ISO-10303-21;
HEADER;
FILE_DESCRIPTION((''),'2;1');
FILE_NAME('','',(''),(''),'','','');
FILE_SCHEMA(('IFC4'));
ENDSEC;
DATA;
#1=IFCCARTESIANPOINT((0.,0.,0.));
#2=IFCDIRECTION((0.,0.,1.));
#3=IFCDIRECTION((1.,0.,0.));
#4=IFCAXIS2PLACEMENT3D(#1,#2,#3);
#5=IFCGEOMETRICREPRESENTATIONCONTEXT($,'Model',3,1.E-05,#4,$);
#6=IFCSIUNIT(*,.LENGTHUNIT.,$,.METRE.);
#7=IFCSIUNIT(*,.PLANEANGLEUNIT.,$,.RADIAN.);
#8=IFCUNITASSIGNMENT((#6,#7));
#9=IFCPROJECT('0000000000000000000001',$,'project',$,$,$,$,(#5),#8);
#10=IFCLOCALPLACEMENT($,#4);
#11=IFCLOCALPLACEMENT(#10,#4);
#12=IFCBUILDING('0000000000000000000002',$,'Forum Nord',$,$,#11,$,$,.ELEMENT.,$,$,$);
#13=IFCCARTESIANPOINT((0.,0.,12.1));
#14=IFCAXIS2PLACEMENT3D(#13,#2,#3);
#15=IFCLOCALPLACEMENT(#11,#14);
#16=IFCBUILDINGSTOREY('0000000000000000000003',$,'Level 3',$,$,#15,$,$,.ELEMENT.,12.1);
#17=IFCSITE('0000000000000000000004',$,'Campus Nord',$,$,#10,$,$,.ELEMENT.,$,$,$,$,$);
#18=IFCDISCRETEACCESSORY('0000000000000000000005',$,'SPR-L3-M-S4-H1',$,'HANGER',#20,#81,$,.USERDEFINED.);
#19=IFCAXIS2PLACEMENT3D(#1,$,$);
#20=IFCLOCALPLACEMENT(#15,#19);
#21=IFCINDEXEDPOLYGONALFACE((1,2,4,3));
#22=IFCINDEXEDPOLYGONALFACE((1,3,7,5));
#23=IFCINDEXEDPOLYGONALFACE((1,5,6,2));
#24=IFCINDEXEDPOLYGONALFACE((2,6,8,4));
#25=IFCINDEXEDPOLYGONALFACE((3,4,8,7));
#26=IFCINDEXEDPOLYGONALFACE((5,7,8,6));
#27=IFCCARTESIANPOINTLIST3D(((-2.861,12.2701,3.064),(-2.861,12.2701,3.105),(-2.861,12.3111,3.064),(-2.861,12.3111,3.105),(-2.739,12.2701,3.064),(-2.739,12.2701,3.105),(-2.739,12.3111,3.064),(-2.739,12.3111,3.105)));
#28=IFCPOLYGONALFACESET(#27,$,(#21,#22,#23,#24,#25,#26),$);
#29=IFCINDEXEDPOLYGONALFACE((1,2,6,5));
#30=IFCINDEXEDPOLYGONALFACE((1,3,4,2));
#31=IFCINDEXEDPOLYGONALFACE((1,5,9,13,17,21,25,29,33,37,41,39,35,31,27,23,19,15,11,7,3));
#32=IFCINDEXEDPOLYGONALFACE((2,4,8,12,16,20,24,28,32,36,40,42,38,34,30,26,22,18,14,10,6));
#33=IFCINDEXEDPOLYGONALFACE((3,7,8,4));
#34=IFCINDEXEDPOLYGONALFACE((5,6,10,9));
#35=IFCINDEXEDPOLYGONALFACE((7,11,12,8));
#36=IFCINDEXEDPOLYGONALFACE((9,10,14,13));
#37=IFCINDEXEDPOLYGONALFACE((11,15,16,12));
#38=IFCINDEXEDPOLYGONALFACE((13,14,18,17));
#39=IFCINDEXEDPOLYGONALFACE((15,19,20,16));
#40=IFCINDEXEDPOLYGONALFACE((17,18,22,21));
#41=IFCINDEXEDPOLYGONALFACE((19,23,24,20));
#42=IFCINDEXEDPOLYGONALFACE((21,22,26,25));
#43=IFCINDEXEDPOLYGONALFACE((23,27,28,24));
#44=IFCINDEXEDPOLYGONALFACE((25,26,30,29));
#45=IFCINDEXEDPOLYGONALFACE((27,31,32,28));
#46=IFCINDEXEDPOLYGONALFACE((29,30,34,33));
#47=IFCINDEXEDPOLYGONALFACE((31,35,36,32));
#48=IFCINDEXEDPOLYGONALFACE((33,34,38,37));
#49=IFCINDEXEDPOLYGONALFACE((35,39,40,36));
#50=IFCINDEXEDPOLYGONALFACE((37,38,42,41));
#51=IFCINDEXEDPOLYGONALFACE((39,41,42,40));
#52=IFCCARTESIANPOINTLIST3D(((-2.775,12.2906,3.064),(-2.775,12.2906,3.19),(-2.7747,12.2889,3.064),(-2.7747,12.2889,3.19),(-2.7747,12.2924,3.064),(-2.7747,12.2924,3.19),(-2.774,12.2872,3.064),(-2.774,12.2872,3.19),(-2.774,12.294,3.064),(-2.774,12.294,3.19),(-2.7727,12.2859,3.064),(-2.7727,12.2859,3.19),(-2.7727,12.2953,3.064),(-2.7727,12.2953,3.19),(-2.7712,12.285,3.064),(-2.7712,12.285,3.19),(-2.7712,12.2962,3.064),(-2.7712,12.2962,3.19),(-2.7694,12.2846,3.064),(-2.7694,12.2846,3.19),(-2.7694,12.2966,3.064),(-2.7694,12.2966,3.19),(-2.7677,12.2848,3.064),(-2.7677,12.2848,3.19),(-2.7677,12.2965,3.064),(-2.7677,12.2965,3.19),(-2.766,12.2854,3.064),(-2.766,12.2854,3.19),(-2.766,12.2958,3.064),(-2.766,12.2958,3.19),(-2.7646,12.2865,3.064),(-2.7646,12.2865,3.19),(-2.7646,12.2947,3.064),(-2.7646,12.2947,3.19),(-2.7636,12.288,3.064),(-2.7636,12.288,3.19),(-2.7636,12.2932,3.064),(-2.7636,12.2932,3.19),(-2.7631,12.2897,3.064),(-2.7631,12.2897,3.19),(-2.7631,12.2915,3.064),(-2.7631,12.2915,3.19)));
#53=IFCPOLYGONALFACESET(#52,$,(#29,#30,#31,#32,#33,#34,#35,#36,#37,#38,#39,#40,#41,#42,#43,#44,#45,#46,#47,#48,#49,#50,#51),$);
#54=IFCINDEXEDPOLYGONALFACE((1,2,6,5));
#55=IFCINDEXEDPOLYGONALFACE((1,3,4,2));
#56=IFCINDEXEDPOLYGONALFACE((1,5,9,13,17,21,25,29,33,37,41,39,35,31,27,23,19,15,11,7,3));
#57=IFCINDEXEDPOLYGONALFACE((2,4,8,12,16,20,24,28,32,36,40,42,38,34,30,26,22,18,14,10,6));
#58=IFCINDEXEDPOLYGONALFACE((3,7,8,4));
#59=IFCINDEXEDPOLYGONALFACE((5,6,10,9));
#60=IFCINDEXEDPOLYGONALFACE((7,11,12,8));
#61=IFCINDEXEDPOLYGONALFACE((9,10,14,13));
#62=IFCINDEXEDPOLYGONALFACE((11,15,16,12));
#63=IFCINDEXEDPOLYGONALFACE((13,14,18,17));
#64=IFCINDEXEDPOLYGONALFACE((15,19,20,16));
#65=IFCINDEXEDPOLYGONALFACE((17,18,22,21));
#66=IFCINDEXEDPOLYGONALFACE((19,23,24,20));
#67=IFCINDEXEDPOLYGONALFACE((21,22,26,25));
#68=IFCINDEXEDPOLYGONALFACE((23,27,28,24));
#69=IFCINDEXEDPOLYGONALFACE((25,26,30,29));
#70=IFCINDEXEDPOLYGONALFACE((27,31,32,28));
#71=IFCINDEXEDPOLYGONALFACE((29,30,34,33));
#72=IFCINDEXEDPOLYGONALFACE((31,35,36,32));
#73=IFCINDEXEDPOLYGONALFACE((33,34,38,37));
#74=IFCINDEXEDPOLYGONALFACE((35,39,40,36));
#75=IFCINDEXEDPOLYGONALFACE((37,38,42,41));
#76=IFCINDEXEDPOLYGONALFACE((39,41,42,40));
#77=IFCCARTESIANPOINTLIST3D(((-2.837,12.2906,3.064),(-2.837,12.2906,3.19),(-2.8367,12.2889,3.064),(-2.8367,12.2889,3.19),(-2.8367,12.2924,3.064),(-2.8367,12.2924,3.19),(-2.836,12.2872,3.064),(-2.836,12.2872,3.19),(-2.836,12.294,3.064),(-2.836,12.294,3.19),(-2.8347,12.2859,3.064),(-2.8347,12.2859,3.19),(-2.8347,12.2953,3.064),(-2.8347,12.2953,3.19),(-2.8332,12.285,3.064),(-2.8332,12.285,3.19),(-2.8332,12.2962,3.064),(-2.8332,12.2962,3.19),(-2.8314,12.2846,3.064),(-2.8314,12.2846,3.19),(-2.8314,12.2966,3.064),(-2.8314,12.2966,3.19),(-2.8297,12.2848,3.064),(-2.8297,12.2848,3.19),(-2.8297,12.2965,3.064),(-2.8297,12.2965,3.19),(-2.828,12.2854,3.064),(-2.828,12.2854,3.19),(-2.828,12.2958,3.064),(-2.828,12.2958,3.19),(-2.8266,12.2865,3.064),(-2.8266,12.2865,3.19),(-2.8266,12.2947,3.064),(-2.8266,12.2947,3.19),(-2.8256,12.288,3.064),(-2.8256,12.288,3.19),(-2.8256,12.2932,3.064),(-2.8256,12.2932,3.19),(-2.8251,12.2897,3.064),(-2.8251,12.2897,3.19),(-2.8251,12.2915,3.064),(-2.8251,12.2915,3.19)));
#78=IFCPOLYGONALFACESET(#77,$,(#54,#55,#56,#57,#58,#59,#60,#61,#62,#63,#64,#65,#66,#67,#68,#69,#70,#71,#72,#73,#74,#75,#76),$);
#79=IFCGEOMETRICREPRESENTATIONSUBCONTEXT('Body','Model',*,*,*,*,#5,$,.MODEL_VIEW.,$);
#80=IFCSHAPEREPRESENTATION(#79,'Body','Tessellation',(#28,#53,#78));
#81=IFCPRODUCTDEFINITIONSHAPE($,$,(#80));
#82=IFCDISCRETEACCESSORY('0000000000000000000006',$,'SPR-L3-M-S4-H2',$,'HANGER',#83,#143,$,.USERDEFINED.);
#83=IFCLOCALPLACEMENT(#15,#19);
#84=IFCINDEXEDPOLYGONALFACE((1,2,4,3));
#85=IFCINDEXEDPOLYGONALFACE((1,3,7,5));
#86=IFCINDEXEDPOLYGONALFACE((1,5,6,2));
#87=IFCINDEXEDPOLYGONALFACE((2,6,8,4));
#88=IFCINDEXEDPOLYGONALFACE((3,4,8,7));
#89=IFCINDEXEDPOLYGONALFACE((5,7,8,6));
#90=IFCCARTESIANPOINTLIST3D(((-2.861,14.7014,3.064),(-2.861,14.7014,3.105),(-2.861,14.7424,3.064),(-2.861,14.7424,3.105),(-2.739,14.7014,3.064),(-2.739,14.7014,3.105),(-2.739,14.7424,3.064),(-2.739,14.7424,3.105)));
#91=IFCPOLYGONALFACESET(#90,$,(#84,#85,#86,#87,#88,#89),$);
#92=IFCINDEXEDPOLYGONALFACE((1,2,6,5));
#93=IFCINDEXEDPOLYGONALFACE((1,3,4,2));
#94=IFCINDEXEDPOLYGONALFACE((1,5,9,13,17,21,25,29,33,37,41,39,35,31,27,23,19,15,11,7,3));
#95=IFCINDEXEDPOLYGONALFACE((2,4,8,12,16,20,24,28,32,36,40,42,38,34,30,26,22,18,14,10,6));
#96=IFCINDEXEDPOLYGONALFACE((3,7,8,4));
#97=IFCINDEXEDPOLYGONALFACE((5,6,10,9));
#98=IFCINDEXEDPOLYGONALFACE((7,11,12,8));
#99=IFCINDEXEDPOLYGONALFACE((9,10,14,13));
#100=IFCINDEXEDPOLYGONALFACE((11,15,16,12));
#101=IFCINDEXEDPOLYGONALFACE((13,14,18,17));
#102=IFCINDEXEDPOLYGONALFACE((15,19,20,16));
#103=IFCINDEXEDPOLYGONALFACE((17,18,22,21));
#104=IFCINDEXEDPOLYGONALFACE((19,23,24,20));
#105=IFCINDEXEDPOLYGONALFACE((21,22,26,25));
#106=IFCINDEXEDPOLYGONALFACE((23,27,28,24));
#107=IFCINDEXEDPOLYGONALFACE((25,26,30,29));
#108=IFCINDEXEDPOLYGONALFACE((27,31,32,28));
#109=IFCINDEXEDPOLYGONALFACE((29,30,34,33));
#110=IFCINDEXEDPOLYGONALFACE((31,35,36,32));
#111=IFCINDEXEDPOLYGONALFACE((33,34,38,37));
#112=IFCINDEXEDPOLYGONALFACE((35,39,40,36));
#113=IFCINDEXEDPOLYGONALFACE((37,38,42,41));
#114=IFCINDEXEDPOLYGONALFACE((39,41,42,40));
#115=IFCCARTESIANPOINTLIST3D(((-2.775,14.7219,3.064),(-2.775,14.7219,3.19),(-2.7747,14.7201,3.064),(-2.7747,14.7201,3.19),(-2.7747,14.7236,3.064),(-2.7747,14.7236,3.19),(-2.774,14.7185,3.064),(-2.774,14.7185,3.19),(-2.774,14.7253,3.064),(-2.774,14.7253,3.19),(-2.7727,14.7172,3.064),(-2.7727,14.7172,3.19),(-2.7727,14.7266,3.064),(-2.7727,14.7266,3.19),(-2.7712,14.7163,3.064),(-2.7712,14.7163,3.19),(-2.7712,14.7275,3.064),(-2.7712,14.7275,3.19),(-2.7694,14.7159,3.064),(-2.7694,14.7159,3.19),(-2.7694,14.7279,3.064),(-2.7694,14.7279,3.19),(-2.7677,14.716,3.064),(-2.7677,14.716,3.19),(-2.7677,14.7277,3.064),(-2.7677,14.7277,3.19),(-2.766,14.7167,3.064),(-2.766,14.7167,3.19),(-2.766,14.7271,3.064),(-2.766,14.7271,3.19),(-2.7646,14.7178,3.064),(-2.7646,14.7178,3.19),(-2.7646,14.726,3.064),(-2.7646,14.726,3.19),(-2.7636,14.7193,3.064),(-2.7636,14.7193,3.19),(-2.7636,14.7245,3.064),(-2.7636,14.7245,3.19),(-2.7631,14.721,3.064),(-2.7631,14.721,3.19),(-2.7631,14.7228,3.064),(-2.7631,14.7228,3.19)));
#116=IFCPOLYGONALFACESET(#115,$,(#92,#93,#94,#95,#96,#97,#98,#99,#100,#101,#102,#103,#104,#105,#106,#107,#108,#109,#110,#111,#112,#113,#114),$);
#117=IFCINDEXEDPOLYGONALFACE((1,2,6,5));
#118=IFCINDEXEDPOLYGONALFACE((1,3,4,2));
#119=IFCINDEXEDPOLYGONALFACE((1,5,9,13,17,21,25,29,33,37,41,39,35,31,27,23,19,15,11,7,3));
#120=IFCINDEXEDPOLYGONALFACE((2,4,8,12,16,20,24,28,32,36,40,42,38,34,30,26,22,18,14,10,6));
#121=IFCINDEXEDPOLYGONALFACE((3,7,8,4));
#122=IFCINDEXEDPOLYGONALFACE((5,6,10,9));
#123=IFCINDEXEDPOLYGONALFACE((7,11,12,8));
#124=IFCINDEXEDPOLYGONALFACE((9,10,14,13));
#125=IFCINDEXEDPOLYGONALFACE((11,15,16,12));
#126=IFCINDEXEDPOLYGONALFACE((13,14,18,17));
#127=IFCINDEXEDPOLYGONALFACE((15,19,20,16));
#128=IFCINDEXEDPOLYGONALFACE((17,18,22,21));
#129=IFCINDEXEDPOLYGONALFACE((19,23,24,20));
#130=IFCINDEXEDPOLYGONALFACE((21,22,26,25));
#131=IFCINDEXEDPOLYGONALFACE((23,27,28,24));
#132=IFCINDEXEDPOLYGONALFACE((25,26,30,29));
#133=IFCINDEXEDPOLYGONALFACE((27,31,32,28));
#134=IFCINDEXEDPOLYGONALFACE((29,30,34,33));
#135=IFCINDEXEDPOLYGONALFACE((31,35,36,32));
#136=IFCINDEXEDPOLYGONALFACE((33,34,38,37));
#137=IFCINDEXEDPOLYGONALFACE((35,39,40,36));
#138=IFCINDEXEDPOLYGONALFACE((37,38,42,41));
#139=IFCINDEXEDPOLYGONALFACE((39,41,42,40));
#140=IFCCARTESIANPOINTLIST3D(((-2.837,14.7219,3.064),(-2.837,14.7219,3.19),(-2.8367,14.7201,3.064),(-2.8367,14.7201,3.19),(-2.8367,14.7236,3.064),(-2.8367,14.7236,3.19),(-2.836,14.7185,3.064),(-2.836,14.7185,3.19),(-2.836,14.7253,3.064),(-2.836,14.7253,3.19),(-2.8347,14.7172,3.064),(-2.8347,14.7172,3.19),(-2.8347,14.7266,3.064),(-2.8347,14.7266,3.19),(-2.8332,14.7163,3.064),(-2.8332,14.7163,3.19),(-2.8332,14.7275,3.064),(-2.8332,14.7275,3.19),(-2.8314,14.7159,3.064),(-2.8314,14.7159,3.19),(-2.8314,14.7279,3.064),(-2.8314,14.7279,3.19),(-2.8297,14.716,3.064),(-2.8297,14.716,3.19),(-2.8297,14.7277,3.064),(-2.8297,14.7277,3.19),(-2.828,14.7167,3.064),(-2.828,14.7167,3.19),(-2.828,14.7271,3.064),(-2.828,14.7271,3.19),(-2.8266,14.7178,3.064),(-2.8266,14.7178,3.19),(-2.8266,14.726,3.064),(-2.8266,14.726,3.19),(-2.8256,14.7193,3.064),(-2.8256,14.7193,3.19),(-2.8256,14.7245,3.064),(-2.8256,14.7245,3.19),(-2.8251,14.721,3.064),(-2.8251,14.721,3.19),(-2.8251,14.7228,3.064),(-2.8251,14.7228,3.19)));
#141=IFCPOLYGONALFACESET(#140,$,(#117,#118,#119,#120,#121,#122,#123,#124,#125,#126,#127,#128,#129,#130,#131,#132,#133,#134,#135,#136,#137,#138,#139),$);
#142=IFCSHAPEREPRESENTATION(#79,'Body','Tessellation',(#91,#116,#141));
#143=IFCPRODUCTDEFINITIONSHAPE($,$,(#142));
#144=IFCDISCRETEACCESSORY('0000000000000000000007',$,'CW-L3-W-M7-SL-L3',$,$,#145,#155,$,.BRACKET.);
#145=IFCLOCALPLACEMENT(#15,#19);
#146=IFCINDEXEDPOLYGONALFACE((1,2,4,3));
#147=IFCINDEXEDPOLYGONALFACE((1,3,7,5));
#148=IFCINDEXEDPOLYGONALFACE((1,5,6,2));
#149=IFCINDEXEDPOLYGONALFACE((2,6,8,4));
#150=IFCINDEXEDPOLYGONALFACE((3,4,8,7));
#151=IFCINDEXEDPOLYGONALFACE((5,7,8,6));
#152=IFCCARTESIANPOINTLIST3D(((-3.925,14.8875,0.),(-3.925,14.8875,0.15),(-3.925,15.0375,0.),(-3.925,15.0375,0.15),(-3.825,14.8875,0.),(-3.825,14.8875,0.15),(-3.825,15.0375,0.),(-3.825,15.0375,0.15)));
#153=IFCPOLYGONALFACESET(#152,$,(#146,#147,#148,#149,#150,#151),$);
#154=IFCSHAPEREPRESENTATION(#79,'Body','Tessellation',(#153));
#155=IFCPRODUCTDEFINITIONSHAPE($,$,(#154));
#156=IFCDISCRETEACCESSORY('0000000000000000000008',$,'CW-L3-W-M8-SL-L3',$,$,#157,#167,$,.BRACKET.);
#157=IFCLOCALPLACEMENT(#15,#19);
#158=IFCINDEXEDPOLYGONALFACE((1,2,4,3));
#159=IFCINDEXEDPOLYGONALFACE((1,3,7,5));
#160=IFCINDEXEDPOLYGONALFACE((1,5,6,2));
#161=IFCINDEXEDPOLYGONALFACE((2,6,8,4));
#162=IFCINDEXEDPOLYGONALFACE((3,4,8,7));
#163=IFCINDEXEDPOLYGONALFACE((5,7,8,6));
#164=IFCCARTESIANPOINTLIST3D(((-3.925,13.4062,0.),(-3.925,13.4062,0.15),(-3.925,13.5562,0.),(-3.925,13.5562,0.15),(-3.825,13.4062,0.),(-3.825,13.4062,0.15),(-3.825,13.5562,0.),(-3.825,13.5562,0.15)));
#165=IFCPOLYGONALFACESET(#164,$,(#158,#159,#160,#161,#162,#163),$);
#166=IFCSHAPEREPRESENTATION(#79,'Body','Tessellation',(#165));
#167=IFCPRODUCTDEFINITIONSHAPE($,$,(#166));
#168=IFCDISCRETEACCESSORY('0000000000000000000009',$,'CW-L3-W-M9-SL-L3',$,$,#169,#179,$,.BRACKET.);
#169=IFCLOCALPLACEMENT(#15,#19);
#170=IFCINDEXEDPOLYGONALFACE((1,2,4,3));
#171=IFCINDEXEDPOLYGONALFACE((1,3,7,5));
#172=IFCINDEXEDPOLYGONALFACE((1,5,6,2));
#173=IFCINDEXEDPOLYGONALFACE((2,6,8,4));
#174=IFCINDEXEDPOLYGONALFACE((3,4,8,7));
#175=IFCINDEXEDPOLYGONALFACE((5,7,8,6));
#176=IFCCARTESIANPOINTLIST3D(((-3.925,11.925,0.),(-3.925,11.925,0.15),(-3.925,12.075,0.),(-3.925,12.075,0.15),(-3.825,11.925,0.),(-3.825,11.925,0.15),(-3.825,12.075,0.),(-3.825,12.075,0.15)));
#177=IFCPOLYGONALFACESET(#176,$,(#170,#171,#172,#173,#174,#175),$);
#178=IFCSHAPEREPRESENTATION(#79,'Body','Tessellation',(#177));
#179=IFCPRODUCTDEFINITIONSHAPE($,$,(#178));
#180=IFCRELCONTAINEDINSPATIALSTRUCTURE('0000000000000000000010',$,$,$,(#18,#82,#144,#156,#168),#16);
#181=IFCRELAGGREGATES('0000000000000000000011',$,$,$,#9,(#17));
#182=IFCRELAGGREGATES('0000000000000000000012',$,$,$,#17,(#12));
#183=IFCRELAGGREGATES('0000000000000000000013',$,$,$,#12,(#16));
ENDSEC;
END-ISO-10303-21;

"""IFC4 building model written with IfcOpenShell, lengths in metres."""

from ifc_helpers import new_model, si_unit, frame, frame_2d, origin_with_axes, origin_2d_with_axis, place, context, subcontext, project, spatial, rectangle, circle, extrude, element, save


model = new_model("IFC4")

# Units and contexts
model_context = context("Model", 3, precision=1e-05, world=origin_with_axes())
body_context = subcontext(model_context, "Body", "Model", "MODEL_VIEW")
ifc_project = project(units=[si_unit("LENGTHUNIT", "METRE"), si_unit("PLANEANGLEUNIT", "RADIAN")], contexts=[model_context])

# Site, building, storey
site_placement = place(None, origin_with_axes())
site = spatial("IfcSite", under=ifc_project, at=site_placement, Name="Campus Nord", CompositionType="ELEMENT")
building_placement = place(site_placement, origin_with_axes())
building = spatial("IfcBuilding", under=site, at=building_placement, Name="Forum Nord", CompositionType="ELEMENT")
storey_placement = place(building_placement, frame((0.0, 0.0, 12.1), z_axis=(0.0, 0.0, 1.0), x_axis=(1.0, 0.0, 0.0)))
storey = spatial("IfcBuildingStorey", under=building, at=storey_placement, Name="Level 3", CompositionType="ELEMENT", Elevation=12.1)

# Discrete accessories
for number, where, z_axis, x_axis, name in (
    (1, (-2.8, 12.2906, 3.105), (0.0, 0.0, 1.0), (-1.0, 0.0, 0.0), "SPR-L3-M-S4-H1"),
    (2, (-2.8, 14.7219, 3.105), (0.0, 0.0, 1.0), (-1.0, 0.0, 0.0), "SPR-L3-M-S4-H2"),
):
    element("IfcDiscreteAccessory", number, at=place(storey_placement, frame(where, z_axis=z_axis, x_axis=x_axis)), inside=storey, Name=name, ObjectType="HANGER", PredefinedType="USERDEFINED", context=body_context, shape_type="SweptSolid", body=[
        extrude(rectangle(XDim=0.122, YDim=0.041, at=origin_2d_with_axis()), frame((0.0, 0.0, -0.041), z_axis=(0.0, 0.0, 1.0), x_axis=(1.0, 0.0, 0.0)), (0.0, 0.0, 1.0), 0.041),
        extrude(circle(Radius=0.006, at=frame_2d((-0.031, 0.0), x_axis=(1.0, 0.0))), frame((0.0, 0.0, -0.041), z_axis=(0.0, 0.0, 1.0), x_axis=(1.0, 0.0, 0.0)), (0.0, 0.0, 1.0), 0.126),
        extrude(circle(Radius=0.006, at=frame_2d((0.031, 0.0), x_axis=(1.0, 0.0))), frame((0.0, 0.0, -0.041), z_axis=(0.0, 0.0, 1.0), x_axis=(1.0, 0.0, 0.0)), (0.0, 0.0, 1.0), 0.126),
    ])
for number, where, z_axis, x_axis, name in (
    (3, (-3.875, 14.9625, 0.0), (0.0, 0.0, 1.0), (0.0, -1.0, 0.0), "CW-L3-W-M7-SL-L3"),
    (4, (-3.875, 13.4812, 0.0), (0.0, 0.0, 1.0), (0.0, -1.0, 0.0), "CW-L3-W-M8-SL-L3"),
    (5, (-3.875, 12.0, 0.0), (0.0, 0.0, 1.0), (0.0, -1.0, 0.0), "CW-L3-W-M9-SL-L3"),
):
    element("IfcDiscreteAccessory", number, at=place(storey_placement, frame(where, z_axis=z_axis, x_axis=x_axis)), inside=storey, Name=name, PredefinedType="BRACKET", context=body_context, shape_type="SweptSolid", body=[
        extrude(rectangle(XDim=0.15, YDim=0.1, at=origin_2d_with_axis()), origin_with_axes(), (0.0, 0.0, 1.0), 0.15),
    ])

save(model, "model.ifc")
